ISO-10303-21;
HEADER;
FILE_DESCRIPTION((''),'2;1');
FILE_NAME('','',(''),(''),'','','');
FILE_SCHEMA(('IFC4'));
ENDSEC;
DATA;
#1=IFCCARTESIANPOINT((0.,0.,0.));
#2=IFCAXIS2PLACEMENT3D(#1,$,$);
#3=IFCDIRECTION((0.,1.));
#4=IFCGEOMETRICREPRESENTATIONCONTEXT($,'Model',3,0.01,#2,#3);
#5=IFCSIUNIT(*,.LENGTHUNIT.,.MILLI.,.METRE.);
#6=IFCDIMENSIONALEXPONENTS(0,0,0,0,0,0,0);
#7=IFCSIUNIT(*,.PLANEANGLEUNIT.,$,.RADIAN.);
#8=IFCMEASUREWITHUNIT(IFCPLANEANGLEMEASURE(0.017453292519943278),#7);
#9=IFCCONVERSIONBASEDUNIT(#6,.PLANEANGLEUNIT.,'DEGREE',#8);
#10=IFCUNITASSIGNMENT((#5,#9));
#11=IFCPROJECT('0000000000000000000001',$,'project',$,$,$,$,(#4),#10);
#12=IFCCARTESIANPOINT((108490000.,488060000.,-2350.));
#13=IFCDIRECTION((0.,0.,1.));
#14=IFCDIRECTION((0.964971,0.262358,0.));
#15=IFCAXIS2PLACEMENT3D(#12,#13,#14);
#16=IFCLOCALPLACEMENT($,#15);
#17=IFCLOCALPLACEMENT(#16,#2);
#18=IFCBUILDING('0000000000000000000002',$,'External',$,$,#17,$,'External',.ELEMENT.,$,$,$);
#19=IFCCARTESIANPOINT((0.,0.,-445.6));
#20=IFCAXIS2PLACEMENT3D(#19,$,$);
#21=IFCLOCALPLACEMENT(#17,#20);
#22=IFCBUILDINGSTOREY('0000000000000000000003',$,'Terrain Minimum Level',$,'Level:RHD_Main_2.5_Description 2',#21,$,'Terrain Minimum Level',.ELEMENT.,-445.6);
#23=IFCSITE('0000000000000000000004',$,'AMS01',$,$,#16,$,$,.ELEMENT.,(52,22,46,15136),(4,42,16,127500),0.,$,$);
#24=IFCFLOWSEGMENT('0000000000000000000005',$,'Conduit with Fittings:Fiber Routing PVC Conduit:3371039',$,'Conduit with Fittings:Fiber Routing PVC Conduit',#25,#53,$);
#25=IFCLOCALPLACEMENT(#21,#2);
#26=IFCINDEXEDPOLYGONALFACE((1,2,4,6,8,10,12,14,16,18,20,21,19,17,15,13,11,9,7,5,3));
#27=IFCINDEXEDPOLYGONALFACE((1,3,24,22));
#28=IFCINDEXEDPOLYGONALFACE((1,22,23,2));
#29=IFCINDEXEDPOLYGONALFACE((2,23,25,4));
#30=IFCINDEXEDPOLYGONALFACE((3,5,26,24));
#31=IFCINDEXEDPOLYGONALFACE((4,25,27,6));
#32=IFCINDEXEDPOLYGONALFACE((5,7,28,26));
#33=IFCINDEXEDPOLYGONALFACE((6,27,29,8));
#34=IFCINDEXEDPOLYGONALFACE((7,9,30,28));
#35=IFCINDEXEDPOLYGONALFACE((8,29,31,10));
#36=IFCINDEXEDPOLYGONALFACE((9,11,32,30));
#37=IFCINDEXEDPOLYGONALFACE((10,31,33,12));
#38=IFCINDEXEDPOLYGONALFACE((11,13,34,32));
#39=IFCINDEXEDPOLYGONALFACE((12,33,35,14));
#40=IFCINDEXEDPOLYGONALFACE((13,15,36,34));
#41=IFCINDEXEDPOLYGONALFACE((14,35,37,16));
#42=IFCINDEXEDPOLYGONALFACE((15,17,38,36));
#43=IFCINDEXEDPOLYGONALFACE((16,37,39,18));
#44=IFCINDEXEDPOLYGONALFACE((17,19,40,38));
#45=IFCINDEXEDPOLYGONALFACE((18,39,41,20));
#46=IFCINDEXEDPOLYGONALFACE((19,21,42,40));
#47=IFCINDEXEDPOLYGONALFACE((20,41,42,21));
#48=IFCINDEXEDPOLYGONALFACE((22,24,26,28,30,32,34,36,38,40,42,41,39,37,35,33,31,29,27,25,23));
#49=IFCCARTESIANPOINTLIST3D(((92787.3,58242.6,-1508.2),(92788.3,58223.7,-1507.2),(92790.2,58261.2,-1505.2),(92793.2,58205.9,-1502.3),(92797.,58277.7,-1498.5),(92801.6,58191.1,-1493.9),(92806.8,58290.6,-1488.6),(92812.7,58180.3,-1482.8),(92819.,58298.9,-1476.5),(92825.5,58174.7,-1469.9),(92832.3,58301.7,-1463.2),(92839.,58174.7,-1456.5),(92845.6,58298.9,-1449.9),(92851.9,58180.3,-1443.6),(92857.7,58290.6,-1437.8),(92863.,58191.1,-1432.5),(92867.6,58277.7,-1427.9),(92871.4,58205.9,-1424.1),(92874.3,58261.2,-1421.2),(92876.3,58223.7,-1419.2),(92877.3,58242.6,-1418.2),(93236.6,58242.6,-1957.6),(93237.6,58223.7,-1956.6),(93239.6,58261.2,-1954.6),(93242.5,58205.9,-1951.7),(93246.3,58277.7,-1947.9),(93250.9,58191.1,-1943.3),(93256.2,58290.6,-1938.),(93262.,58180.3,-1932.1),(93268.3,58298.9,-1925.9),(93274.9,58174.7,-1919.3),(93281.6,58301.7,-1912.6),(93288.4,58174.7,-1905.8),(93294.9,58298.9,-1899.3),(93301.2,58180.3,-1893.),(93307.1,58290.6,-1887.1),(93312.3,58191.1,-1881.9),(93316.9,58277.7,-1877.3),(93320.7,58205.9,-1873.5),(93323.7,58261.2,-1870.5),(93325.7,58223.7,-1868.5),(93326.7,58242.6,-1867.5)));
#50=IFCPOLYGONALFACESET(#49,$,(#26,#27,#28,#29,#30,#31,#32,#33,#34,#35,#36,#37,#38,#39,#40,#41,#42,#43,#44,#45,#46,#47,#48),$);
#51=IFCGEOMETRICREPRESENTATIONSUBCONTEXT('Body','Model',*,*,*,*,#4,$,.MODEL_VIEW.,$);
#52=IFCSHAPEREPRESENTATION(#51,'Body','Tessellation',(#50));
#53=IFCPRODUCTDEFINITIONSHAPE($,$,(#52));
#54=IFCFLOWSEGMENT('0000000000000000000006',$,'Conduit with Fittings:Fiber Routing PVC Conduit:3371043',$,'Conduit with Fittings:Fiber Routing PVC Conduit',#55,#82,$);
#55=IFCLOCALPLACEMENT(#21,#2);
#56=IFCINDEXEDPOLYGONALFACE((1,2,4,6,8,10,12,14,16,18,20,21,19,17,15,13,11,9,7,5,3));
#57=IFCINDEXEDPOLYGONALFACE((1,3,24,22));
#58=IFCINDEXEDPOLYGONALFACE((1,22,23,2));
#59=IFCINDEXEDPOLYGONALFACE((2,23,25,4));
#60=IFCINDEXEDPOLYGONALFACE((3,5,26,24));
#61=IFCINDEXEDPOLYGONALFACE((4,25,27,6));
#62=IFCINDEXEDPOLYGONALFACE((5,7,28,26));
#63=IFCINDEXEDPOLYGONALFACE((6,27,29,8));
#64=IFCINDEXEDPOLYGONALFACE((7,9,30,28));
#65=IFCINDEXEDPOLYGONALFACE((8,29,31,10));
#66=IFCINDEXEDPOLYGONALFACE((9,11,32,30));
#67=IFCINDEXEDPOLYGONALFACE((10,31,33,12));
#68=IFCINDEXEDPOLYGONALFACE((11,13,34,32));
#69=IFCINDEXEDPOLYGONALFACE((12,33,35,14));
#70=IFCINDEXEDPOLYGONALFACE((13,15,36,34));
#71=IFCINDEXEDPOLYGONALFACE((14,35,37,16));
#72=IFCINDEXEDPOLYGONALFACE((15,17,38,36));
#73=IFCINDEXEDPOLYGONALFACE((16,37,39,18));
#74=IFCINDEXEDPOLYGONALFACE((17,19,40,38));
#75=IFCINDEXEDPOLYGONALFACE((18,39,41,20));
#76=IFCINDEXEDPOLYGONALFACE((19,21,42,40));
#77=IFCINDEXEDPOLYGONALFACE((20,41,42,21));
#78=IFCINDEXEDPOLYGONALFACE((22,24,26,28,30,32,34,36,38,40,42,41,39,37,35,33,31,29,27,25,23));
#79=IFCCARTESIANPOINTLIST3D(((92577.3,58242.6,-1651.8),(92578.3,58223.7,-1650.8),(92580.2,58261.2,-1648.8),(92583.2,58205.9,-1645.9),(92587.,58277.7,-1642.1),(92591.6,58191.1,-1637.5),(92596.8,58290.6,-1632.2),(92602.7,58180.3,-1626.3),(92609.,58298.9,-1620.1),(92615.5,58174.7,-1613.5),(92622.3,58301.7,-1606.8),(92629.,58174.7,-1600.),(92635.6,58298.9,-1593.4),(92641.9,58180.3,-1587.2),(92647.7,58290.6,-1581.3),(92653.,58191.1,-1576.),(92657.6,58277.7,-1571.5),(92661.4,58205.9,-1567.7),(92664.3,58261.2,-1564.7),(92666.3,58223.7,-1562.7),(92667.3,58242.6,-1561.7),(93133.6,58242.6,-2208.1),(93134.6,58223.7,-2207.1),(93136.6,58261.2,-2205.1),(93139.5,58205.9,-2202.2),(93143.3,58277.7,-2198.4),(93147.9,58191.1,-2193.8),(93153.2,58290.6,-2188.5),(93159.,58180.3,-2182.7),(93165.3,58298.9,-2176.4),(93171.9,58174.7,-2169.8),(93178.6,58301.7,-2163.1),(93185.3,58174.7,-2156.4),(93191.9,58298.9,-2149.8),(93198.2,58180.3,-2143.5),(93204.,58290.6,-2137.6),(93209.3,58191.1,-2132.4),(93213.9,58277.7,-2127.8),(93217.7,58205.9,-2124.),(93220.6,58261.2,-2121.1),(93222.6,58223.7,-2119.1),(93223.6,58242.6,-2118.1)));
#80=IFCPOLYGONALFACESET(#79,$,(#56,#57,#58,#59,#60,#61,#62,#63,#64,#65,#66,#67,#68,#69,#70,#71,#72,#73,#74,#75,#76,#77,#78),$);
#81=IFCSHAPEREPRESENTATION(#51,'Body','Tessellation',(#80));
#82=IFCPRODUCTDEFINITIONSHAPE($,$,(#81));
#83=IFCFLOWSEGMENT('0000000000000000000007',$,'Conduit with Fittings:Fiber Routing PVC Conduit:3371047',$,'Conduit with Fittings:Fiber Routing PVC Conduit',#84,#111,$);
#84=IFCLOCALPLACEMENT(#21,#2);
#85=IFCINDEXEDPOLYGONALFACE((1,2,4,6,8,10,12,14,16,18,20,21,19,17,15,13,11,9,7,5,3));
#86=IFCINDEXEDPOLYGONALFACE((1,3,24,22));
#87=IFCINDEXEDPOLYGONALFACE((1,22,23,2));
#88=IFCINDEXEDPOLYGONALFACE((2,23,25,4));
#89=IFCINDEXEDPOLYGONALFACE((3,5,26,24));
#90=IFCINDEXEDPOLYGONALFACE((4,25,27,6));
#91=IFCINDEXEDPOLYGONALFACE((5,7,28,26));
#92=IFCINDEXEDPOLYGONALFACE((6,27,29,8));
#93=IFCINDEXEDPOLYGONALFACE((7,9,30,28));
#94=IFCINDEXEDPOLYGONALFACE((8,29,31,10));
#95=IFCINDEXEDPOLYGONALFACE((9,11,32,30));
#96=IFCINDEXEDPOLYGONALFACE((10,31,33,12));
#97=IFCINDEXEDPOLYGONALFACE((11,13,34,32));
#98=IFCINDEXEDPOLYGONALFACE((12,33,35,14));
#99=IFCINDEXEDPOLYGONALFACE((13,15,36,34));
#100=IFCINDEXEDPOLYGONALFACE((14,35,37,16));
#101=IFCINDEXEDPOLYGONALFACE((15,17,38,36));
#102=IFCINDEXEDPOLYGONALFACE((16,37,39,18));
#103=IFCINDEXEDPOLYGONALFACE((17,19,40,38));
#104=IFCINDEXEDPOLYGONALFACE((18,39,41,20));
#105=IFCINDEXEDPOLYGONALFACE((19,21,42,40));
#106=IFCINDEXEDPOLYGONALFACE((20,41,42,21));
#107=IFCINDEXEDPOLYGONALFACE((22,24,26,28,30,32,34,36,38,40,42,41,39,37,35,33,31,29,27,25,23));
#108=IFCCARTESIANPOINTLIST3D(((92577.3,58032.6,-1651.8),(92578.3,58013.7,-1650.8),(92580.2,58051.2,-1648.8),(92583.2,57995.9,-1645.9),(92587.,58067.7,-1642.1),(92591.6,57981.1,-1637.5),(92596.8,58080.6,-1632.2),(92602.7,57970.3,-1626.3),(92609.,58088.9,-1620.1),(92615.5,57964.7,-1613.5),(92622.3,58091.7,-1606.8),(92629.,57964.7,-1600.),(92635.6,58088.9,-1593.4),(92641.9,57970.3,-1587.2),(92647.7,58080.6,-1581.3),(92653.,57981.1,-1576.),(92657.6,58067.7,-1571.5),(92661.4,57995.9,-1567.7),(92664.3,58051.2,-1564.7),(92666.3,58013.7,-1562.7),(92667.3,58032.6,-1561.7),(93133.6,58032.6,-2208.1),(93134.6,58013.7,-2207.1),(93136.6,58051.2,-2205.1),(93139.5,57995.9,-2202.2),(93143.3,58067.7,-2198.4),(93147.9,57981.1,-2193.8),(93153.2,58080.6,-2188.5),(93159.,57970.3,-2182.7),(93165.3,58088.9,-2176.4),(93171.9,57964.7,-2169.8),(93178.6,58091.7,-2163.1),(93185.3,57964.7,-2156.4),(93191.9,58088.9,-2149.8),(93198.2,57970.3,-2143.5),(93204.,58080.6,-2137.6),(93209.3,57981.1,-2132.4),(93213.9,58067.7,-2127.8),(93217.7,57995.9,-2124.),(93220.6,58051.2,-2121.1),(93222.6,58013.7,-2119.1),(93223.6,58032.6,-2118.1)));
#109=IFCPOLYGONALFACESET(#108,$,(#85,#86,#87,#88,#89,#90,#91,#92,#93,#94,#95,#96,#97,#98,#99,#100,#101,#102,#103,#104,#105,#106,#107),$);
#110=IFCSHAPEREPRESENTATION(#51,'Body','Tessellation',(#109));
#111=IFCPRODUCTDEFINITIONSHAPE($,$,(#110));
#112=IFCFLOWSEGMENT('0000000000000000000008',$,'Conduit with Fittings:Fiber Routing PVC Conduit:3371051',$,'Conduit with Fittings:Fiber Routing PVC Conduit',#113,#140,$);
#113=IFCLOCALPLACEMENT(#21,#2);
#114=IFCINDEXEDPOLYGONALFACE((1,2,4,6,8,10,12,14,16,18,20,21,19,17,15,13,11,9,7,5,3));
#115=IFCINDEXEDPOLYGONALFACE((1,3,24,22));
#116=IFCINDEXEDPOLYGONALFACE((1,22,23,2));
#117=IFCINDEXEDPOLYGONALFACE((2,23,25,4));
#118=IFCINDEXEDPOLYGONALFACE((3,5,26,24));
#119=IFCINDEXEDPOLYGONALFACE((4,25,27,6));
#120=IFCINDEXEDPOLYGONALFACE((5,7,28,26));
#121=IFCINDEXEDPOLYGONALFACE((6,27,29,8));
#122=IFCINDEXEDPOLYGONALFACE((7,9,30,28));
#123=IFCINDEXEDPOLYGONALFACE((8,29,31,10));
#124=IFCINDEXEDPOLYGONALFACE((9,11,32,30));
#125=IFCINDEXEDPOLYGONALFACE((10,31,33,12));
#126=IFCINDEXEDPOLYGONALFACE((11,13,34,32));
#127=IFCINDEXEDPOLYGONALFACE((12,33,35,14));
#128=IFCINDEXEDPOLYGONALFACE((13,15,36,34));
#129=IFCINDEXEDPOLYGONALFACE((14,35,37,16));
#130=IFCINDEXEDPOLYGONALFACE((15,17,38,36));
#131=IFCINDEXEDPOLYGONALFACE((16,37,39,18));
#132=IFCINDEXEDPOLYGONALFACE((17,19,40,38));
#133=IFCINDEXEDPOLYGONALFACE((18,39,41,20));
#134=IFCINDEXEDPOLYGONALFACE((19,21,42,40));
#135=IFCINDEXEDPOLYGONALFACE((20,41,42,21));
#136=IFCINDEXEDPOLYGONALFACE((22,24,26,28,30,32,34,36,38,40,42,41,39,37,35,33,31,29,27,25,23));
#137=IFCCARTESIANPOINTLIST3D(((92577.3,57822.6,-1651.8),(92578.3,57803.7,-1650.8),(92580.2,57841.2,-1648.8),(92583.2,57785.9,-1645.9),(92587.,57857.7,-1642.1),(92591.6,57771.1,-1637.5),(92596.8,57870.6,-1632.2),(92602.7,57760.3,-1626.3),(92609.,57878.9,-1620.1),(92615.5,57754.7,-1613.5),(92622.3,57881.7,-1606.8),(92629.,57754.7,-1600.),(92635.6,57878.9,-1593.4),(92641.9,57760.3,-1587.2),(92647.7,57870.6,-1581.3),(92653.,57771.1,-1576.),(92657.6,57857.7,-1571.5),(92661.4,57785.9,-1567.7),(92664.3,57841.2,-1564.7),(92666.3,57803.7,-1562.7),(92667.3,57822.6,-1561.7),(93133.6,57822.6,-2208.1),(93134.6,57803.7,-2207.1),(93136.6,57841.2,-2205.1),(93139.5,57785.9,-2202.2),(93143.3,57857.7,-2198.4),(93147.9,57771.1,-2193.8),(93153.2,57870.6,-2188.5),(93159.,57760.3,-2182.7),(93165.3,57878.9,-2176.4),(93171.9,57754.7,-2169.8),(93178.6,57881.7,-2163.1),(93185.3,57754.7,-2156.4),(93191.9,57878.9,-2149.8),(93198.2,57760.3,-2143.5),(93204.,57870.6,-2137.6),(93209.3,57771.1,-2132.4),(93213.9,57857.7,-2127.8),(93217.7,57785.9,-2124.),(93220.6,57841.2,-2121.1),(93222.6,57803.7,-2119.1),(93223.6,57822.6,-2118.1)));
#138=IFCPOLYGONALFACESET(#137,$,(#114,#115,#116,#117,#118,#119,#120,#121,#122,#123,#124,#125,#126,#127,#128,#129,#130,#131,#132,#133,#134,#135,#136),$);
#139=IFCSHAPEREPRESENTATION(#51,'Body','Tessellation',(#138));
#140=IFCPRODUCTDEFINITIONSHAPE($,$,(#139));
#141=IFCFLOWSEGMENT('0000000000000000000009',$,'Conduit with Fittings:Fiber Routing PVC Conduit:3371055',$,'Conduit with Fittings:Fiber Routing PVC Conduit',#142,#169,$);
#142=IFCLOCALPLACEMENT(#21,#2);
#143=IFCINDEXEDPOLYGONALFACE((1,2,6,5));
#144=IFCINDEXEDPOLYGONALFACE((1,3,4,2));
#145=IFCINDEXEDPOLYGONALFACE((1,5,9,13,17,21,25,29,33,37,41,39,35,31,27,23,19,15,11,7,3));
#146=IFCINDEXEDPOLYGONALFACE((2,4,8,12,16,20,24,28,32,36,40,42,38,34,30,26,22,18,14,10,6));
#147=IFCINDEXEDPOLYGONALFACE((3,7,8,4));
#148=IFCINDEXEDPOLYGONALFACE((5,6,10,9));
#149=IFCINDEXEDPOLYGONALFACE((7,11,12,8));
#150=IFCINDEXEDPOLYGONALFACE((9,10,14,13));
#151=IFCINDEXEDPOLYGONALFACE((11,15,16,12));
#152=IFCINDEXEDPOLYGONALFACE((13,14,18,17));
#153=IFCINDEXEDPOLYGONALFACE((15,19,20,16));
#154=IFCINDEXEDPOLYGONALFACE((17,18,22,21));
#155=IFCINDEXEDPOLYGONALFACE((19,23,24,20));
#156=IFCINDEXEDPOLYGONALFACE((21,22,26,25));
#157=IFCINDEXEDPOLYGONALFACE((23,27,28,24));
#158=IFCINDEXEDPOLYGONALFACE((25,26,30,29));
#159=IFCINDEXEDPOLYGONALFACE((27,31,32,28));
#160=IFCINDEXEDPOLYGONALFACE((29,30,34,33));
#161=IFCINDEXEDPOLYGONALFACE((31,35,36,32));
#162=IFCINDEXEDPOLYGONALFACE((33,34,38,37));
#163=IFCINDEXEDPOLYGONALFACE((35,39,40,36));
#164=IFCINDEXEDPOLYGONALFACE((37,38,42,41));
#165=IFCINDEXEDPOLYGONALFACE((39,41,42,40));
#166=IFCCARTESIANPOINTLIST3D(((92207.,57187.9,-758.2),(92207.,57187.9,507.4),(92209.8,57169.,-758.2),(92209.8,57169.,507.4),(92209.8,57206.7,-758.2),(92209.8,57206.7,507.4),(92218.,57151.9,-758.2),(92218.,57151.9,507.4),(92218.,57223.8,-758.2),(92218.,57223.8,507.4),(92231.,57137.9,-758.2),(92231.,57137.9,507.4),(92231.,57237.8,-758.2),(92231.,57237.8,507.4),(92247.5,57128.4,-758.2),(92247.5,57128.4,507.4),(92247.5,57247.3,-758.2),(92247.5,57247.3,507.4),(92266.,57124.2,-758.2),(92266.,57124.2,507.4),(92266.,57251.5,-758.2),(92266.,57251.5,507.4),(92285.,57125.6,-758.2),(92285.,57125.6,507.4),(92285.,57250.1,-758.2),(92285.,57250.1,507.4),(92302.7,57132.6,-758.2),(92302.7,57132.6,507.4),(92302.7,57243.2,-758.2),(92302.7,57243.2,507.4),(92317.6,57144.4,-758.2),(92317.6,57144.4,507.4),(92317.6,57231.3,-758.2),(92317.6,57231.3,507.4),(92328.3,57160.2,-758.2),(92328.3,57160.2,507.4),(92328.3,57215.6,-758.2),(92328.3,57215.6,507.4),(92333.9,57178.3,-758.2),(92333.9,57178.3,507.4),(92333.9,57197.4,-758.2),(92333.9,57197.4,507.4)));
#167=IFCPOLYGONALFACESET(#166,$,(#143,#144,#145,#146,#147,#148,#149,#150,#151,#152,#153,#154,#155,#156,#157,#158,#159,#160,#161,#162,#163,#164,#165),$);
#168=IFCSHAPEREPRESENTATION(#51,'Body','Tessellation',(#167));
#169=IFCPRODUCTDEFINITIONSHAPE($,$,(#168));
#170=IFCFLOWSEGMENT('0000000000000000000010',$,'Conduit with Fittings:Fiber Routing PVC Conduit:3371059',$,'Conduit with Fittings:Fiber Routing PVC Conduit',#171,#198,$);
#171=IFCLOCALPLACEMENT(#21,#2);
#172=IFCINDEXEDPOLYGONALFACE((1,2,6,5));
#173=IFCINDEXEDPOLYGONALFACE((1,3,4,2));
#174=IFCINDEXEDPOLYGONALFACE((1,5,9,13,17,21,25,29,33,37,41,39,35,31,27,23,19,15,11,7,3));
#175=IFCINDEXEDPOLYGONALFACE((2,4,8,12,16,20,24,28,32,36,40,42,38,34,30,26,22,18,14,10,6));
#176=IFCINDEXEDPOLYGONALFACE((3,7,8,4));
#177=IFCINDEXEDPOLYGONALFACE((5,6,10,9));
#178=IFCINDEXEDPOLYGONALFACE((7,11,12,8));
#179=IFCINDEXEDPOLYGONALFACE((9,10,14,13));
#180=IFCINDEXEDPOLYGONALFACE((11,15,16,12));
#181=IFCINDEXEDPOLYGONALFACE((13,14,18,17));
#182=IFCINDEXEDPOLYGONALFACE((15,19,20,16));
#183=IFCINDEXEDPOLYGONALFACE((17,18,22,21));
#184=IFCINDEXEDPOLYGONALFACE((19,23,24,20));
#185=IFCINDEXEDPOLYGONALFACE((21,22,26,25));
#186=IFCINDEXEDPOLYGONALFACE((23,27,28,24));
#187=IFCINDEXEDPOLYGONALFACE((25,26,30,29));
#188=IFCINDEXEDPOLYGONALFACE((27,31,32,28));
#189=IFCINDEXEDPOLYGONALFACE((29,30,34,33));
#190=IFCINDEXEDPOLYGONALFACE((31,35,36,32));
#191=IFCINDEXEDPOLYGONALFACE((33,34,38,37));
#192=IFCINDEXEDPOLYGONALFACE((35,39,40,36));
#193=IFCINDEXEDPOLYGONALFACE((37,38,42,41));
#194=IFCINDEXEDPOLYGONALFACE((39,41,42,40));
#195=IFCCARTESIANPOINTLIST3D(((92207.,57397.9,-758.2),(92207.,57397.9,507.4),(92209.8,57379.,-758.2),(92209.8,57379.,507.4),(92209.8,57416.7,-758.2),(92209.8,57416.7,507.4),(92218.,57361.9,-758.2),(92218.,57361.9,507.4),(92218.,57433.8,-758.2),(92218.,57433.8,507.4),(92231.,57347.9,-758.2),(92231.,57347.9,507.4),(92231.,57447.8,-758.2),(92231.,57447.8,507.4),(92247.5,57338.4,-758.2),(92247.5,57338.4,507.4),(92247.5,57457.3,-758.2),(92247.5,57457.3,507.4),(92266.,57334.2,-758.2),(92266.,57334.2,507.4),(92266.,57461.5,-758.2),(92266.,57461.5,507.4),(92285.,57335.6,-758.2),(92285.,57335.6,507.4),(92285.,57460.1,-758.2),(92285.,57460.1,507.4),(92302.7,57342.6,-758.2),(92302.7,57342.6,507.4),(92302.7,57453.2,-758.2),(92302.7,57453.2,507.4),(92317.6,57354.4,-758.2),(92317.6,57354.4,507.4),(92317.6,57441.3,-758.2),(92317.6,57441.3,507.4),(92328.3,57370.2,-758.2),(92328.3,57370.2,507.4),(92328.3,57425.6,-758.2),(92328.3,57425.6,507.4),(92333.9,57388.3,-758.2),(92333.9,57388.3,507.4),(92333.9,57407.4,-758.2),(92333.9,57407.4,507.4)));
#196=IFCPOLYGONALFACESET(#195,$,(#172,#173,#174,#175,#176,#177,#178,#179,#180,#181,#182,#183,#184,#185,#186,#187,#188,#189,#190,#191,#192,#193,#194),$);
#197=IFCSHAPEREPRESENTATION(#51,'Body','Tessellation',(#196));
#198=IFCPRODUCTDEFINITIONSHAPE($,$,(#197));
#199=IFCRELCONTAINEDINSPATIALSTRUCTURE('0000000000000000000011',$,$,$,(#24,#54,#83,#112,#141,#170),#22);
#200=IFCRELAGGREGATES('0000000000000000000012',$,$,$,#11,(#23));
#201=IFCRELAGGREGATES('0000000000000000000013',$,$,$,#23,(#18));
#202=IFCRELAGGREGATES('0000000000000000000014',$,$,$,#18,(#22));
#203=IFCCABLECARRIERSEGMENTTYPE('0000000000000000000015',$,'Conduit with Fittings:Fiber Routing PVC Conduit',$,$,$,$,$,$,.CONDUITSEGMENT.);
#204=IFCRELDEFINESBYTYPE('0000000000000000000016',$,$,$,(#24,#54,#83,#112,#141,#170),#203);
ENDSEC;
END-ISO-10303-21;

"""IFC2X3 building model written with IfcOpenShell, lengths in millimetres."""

from ifc_helpers import new_model, entity, si_unit, converted_unit, direction, frame, frame_2d, origin, origin_2d_with_axis, place, context, subcontext, project, spatial, circle, extrude, type_object, element, save


model = new_model("IFC2X3")

# Units and contexts
model_context = context("Model", 3, precision=0.01, world=origin(), true_north=direction((0.0, 1.0)))
body_context = subcontext(model_context, "Body", "Model", "MODEL_VIEW")
ifc_project = project(units=[si_unit("LENGTHUNIT", "METRE", prefix="MILLI"), converted_unit("PLANEANGLEUNIT", "DEGREE", entity("IfcPlaneAngleMeasure", 0.017453292519943278), si_unit("PLANEANGLEUNIT", "RADIAN"), dimensions=[0, 0, 0, 0, 0, 0, 0])], contexts=[model_context])

# Site, building, storey
site_placement = place(None, frame((108490000.0, 488060000.0, -2350.0), z_axis=(0.0, 0.0, 1.0), x_axis=(0.964971, 0.262358, 0.0)))
site = spatial("IfcSite", under=ifc_project, at=site_placement, Name="AMS01", CompositionType="ELEMENT", RefLatitude=(52, 22, 46, 15136), RefLongitude=(4, 42, 16, 127500), RefElevation=0.0)
building_placement = place(site_placement, origin())
building = spatial("IfcBuilding", under=site, at=building_placement, Name="External", LongName="External", CompositionType="ELEMENT")
storey_placement = place(building_placement, frame((0.0, 0.0, -445.6)))
storey = spatial("IfcBuildingStorey", under=building, at=storey_placement, Name="Terrain Minimum Level", ObjectType="Level:RHD_Main_2.5_Description 2", LongName="Terrain Minimum Level", CompositionType="ELEMENT", Elevation=-445.6)

# Flow segments
cable_carrier_segment_type = type_object("IfcCableCarrierSegmentType", Name="Conduit with Fittings:Fiber Routing PVC Conduit", PredefinedType="CONDUITSEGMENT")
flow_segment_1_placement = place(storey_placement, origin())
element("IfcFlowSegment", 1, at=flow_segment_1_placement, inside=storey, type_object=cable_carrier_segment_type, Name="Conduit with Fittings:Fiber Routing PVC Conduit:3371039", ObjectType="Conduit with Fittings:Fiber Routing PVC Conduit", context=body_context, shape_type="SweptSolid", body=[
    extrude(circle(Radius=63.9, at=frame_2d((0.0, 0.0), x_axis=(1.0, 0.0))), frame((92832.3, 58237.9, -1463.2), z_axis=(0.707107, 0.0, -0.707107), x_axis=(0.0, 1.0, 0.0)), (0.0, 0.0, 1.0), 635.5),
])
flow_segment_2_placement = place(storey_placement, origin())
element("IfcFlowSegment", 2, at=flow_segment_2_placement, inside=storey, type_object=cable_carrier_segment_type, Name="Conduit with Fittings:Fiber Routing PVC Conduit:3371043", ObjectType="Conduit with Fittings:Fiber Routing PVC Conduit", context=body_context, shape_type="SweptSolid", body=[
    extrude(circle(Radius=63.9, at=frame_2d((0.0, 0.0), x_axis=(1.0, 0.0))), frame((92622.3, 58237.9, -1606.8), z_axis=(0.707107, 0.0, -0.707107), x_axis=(0.0, 1.0, 0.0)), (0.0, 0.0, 1.0), 786.8),
])
flow_segment_3_placement = place(storey_placement, origin())
element("IfcFlowSegment", 3, at=flow_segment_3_placement, inside=storey, type_object=cable_carrier_segment_type, Name="Conduit with Fittings:Fiber Routing PVC Conduit:3371047", ObjectType="Conduit with Fittings:Fiber Routing PVC Conduit", context=body_context, shape_type="SweptSolid", body=[
    extrude(circle(Radius=63.9, at=origin_2d_with_axis()), frame((93178.6, 58027.9, -2163.1), z_axis=(-0.707107, 0.0, 0.707107), x_axis=(0.0, 1.0, 0.0)), (0.0, 0.0, 1.0), 786.8),
])
flow_segment_4_placement = place(storey_placement, origin())
element("IfcFlowSegment", 4, at=flow_segment_4_placement, inside=storey, type_object=cable_carrier_segment_type, Name="Conduit with Fittings:Fiber Routing PVC Conduit:3371051", ObjectType="Conduit with Fittings:Fiber Routing PVC Conduit", context=body_context, shape_type="SweptSolid", body=[
    extrude(circle(Radius=63.9, at=origin_2d_with_axis()), frame((93178.6, 57817.9, -2163.1), z_axis=(-0.707107, 0.0, 0.707107), x_axis=(0.0, 1.0, 0.0)), (0.0, 0.0, 1.0), 786.8),
])
flow_segment_5_placement = place(storey_placement, origin())
element("IfcFlowSegment", 5, at=flow_segment_5_placement, inside=storey, type_object=cable_carrier_segment_type, Name="Conduit with Fittings:Fiber Routing PVC Conduit:3371055", ObjectType="Conduit with Fittings:Fiber Routing PVC Conduit", context=body_context, shape_type="SweptSolid", body=[
    extrude(circle(Radius=63.9, at=origin_2d_with_axis()), frame((92270.8, 57187.9, -758.2), z_axis=(0.0, 0.0, 1.0), x_axis=(-1.0, 0.0, 0.0)), (0.0, 0.0, 1.0), 1265.7),
])
flow_segment_6_placement = place(storey_placement, origin())
element("IfcFlowSegment", 6, at=flow_segment_6_placement, inside=storey, type_object=cable_carrier_segment_type, Name="Conduit with Fittings:Fiber Routing PVC Conduit:3371059", ObjectType="Conduit with Fittings:Fiber Routing PVC Conduit", context=body_context, shape_type="SweptSolid", body=[
    extrude(circle(Radius=63.9, at=origin_2d_with_axis()), frame((92270.8, 57397.9, -758.2), z_axis=(0.0, 0.0, 1.0), x_axis=(-1.0, 0.0, 0.0)), (0.0, 0.0, 1.0), 1265.7),
])

save(model, "model.ifc")
